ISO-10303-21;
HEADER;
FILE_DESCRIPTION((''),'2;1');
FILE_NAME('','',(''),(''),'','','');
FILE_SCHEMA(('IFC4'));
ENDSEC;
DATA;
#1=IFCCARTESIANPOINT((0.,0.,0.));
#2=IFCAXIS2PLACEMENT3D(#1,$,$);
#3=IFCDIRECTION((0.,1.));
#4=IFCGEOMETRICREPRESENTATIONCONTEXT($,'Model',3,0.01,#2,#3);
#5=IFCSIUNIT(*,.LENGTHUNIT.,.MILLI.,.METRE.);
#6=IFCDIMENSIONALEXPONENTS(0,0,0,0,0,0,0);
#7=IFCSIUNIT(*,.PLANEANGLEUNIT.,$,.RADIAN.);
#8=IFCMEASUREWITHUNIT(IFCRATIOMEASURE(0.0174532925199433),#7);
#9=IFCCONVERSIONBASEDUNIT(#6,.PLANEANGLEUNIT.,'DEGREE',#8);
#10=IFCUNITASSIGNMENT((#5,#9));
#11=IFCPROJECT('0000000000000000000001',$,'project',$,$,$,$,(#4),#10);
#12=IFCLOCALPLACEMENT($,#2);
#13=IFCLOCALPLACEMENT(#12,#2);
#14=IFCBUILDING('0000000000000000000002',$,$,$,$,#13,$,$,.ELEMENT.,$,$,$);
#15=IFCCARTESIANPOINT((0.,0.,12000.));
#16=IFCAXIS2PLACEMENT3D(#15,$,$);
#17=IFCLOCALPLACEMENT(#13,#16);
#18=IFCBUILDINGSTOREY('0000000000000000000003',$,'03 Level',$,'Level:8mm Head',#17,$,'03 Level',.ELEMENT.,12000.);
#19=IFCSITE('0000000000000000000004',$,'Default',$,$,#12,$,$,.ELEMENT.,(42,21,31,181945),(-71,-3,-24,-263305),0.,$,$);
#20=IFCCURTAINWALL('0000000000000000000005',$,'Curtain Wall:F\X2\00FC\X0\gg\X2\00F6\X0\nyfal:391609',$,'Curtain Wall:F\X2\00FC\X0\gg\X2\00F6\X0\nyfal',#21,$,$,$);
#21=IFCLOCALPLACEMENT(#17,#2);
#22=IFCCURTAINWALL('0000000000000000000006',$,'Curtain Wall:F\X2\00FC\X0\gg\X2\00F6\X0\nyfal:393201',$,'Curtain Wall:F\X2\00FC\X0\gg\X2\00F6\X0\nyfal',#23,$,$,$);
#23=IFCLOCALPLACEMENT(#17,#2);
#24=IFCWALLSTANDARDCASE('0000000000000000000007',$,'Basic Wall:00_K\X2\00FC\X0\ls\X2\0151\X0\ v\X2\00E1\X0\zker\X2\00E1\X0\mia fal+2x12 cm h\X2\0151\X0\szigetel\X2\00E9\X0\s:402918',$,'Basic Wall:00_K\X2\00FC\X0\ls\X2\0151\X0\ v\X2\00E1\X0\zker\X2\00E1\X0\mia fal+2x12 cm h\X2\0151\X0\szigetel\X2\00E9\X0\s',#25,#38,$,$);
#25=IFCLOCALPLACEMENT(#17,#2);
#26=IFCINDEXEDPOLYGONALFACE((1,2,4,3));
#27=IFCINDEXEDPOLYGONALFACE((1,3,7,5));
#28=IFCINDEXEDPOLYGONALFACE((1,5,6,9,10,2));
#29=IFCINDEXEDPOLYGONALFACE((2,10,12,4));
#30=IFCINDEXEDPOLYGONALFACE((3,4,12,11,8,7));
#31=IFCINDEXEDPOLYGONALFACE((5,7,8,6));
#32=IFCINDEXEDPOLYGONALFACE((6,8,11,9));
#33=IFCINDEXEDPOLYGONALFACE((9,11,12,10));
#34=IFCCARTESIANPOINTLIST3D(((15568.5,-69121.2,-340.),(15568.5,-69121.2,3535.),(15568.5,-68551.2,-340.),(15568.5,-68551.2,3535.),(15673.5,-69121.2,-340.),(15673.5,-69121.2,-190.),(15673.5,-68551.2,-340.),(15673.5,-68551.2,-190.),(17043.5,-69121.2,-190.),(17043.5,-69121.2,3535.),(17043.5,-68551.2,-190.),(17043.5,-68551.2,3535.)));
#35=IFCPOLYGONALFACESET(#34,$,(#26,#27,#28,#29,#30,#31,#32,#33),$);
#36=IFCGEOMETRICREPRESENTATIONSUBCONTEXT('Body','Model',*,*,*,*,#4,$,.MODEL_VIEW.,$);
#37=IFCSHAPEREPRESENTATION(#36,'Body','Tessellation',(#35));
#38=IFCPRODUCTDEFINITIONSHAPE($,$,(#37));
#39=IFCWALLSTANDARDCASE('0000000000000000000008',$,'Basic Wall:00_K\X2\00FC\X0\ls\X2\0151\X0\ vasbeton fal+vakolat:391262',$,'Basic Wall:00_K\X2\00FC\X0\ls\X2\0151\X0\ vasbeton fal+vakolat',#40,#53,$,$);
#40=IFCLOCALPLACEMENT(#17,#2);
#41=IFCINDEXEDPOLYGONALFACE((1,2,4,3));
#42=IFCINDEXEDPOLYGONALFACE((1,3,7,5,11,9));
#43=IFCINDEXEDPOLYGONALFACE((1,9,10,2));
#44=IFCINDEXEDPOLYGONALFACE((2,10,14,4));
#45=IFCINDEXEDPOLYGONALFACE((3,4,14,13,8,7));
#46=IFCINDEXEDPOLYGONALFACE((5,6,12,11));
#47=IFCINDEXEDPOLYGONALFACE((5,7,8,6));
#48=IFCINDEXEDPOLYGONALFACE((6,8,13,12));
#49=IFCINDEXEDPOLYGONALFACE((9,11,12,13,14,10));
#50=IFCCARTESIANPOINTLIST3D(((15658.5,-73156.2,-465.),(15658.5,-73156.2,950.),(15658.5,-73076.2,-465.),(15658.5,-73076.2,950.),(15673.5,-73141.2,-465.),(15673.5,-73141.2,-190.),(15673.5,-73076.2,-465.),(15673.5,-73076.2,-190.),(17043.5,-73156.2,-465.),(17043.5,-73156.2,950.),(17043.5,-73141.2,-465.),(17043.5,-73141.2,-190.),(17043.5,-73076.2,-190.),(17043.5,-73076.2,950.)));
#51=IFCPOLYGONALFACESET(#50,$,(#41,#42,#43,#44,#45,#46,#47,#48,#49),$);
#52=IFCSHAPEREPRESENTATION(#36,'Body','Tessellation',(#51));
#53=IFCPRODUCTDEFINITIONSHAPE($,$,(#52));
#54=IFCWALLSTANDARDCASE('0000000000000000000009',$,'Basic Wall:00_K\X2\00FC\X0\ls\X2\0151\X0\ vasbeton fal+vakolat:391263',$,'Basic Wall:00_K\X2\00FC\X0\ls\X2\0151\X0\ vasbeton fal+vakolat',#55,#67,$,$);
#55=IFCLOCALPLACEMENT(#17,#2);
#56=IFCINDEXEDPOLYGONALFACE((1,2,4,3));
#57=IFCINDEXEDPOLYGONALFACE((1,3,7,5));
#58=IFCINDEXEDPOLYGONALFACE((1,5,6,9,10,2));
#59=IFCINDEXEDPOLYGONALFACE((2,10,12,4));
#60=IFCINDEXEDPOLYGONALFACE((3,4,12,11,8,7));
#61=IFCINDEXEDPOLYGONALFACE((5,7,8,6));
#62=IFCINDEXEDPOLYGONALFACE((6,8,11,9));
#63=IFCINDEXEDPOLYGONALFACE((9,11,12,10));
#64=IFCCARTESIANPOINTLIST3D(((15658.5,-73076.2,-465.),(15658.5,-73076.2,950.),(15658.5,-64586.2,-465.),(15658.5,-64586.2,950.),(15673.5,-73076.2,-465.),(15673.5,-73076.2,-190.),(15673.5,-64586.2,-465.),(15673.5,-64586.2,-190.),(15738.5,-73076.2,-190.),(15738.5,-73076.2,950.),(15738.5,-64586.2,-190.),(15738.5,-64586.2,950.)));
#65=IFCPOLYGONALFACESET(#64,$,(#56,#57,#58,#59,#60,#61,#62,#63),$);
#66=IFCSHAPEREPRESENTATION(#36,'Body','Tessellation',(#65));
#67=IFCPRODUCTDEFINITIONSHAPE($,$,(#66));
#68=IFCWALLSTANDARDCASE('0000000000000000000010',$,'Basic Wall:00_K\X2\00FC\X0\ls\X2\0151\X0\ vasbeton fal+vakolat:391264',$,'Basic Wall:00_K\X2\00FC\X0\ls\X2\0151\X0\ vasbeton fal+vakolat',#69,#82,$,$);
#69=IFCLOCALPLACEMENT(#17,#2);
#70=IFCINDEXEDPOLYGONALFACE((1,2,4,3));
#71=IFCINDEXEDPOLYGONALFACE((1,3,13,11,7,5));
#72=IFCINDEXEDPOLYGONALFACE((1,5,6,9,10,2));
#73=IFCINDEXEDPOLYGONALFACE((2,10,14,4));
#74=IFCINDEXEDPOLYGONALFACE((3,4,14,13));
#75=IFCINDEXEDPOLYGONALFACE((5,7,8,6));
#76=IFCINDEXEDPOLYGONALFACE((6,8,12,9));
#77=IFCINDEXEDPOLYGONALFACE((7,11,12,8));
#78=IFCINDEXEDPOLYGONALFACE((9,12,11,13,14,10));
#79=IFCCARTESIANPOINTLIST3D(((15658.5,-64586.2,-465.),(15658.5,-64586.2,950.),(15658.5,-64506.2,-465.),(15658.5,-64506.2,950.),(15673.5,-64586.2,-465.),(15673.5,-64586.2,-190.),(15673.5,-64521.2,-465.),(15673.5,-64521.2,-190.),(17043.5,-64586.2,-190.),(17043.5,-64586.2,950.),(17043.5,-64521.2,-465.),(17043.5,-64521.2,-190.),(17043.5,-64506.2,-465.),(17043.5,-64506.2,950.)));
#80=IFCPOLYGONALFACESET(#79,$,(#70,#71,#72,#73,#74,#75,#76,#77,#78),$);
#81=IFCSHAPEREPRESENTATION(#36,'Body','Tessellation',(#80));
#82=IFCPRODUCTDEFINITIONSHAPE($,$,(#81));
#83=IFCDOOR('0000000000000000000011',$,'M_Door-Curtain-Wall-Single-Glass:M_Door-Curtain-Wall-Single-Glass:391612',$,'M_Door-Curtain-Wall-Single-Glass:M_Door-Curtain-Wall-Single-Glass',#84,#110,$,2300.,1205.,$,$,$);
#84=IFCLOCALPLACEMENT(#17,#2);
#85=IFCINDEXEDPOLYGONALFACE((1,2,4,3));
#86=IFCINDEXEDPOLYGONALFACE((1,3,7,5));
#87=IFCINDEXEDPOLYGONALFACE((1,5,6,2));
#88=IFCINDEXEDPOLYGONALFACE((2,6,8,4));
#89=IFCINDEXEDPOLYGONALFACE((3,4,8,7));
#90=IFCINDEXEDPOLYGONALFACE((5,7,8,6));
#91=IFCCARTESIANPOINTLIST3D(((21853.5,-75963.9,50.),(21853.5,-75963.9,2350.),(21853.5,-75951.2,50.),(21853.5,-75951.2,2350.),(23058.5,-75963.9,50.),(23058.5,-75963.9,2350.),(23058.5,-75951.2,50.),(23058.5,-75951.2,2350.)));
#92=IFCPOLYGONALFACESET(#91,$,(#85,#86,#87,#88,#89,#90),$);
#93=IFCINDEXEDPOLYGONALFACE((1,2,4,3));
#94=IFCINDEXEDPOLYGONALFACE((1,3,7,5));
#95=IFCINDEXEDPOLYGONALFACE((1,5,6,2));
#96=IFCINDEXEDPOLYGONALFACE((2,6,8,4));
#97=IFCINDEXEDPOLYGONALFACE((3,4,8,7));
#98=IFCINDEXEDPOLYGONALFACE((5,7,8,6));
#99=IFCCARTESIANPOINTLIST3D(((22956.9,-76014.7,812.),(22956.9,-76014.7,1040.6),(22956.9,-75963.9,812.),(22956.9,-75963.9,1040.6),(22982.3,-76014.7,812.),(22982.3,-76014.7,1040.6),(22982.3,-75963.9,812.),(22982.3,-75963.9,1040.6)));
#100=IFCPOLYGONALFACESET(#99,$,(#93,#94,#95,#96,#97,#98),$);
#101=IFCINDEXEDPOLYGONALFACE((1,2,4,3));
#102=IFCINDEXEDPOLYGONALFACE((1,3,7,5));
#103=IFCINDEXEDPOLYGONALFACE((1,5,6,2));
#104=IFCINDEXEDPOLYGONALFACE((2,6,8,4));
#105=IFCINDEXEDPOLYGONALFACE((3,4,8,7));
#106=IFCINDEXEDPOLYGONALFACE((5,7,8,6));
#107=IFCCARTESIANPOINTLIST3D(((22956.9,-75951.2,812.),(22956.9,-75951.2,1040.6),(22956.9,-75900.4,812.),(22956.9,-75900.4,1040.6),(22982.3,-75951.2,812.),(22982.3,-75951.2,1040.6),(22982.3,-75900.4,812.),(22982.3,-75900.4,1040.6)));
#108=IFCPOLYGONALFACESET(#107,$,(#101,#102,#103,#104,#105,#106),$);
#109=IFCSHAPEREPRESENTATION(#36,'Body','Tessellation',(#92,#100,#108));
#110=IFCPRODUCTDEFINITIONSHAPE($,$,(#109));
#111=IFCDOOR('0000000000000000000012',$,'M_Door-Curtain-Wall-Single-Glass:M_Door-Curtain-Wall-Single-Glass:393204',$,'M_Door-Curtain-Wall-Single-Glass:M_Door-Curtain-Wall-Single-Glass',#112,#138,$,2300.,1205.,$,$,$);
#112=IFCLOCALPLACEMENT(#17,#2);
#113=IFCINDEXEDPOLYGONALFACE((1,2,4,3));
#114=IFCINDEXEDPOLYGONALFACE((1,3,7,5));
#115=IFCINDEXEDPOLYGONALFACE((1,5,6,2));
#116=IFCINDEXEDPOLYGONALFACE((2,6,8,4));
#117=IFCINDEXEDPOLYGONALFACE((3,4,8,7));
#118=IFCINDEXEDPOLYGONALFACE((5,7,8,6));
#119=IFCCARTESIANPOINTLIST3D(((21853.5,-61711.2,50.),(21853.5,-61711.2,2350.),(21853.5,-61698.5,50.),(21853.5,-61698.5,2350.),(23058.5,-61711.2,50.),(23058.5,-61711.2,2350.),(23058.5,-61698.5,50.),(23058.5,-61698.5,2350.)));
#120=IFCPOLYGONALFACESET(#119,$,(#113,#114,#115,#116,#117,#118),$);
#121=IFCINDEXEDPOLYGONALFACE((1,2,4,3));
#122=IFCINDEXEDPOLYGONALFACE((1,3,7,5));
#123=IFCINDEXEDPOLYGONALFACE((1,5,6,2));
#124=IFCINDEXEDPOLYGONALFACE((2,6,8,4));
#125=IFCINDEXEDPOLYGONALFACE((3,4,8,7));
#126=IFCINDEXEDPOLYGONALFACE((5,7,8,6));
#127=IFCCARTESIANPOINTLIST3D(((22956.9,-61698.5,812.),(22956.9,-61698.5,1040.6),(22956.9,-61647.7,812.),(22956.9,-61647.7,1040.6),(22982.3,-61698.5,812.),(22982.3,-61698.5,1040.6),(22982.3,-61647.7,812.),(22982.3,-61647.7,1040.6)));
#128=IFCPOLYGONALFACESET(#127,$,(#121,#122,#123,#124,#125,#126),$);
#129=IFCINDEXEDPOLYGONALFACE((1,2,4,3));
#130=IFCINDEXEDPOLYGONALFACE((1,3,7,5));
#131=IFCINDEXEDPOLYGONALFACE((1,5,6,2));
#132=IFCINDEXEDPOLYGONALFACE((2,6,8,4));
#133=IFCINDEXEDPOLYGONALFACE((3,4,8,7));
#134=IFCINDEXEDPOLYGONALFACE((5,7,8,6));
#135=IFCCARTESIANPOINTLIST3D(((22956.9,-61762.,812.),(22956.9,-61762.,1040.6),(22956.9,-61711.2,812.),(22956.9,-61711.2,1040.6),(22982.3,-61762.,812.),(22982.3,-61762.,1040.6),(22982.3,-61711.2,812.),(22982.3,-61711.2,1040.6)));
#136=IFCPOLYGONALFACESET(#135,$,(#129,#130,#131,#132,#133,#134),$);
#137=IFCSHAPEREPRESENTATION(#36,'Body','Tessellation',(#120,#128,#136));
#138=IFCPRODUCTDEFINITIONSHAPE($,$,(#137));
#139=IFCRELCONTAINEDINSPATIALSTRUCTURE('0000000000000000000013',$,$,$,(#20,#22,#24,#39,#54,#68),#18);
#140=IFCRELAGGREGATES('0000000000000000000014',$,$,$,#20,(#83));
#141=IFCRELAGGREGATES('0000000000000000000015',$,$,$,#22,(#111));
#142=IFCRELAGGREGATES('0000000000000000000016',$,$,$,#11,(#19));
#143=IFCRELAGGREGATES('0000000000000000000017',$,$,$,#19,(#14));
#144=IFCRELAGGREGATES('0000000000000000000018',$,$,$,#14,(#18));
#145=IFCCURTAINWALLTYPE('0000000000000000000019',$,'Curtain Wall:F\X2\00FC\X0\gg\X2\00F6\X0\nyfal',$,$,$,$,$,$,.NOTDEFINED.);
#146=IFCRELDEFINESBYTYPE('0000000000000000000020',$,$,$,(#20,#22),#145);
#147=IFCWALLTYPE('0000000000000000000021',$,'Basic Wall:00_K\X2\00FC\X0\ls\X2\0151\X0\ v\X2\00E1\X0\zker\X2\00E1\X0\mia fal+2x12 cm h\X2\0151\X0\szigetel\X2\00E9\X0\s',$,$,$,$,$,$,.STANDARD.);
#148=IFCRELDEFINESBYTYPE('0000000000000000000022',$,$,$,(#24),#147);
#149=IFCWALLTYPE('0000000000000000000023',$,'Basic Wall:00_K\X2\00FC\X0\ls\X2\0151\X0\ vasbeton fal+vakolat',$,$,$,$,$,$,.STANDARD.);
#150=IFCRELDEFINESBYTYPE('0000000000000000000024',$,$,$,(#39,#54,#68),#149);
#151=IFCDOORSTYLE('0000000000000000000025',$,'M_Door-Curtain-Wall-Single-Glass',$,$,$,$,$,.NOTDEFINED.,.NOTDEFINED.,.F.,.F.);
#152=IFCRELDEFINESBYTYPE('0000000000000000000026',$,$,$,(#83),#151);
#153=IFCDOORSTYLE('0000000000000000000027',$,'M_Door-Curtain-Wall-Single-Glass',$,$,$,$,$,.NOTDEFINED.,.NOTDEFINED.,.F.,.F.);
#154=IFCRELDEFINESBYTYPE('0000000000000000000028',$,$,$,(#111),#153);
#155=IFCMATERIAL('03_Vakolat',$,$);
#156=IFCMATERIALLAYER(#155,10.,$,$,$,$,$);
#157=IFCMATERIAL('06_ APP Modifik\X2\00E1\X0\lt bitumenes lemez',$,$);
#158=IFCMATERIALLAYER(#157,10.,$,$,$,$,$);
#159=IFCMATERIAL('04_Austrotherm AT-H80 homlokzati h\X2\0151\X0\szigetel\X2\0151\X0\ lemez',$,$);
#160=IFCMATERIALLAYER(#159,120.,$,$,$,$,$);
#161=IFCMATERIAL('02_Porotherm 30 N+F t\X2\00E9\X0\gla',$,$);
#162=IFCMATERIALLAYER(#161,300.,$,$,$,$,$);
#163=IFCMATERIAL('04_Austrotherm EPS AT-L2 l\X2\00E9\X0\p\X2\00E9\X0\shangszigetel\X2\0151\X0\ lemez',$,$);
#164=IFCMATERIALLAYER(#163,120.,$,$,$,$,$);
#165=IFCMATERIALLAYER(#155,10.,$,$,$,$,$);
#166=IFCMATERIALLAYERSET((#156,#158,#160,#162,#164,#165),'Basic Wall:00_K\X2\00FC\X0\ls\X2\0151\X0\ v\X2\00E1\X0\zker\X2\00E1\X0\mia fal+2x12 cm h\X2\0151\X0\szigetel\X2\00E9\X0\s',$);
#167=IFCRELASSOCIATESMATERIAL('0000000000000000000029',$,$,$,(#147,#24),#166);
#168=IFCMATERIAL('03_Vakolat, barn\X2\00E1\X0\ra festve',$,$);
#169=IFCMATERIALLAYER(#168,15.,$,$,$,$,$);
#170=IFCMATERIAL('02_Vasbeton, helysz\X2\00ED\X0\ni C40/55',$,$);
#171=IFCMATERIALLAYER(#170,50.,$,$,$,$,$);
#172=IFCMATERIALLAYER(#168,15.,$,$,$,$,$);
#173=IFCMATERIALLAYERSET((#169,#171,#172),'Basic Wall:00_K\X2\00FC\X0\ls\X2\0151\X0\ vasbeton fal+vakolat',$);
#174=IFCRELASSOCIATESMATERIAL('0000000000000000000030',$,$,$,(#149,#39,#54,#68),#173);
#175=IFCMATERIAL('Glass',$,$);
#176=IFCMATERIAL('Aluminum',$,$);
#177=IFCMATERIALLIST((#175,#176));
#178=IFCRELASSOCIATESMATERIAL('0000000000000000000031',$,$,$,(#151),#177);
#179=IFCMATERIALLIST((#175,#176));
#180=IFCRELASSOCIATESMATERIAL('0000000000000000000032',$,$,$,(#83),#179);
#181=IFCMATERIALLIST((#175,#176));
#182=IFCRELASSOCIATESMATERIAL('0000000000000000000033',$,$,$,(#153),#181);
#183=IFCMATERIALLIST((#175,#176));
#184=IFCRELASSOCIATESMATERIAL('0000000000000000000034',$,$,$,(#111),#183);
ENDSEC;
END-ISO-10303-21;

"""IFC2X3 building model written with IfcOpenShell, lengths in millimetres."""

from ifc_helpers import new_model, entity, si_unit, converted_unit, direction, frame, frame_2d, origin, origin_2d_with_axis, place, context, subcontext, project, spatial, polyline, rectangle, extrude, clip, bounded_halfspace, source, transform, mapped, material, material_list, layer, layer_set, layer_usage, type_object, type_shapes, element, aggregate, save


model = new_model("IFC2X3")

# Units and contexts
model_context = context("Model", 3, precision=0.01, world=origin(), true_north=direction((0.0, 1.0)))
body_context = subcontext(model_context, "Body", "Model", "MODEL_VIEW")
ifc_project = project(units=[si_unit("LENGTHUNIT", "METRE", prefix="MILLI"), converted_unit("PLANEANGLEUNIT", "DEGREE", entity("IfcRatioMeasure", 0.0174532925199433), si_unit("PLANEANGLEUNIT", "RADIAN"), dimensions=[0, 0, 0, 0, 0, 0, 0])], contexts=[model_context])

# Site, building, storey
site_placement = place(None, origin())
site = spatial("IfcSite", under=ifc_project, at=site_placement, Name="Default", CompositionType="ELEMENT", RefLatitude=(42, 21, 31, 181945), RefLongitude=(-71, -3, -24, -263305), RefElevation=0.0)
building_placement = place(site_placement, origin())
building = spatial("IfcBuilding", under=site, at=building_placement, CompositionType="ELEMENT")
storey_placement = place(building_placement, frame((0.0, 0.0, 12000.0)))
storey = spatial("IfcBuildingStorey", under=building, at=storey_placement, Name="03 Level", ObjectType="Level:8mm Head", LongName="03 Level", CompositionType="ELEMENT", Elevation=12000.0)

# Curtain walls
curtain_wall_type = type_object("IfcCurtainWallType", Name="Curtain Wall:Függönyfal", PredefinedType="NOTDEFINED")
curtain_wall_1_placement = place(storey_placement, frame((0.0, 0.0, -12000.0)))
curtain_wall_1 = element("IfcCurtainWall", 1, at=curtain_wall_1_placement, inside=storey, type_object=curtain_wall_type, Name="Curtain Wall:Függönyfal:391609", ObjectType="Curtain Wall:Függönyfal")
curtain_wall_2_placement = place(storey_placement, frame((0.0, 0.0, -12000.0)))
curtain_wall_2 = element("IfcCurtainWall", 2, at=curtain_wall_2_placement, inside=storey, type_object=curtain_wall_type, Name="Curtain Wall:Függönyfal:393201", ObjectType="Curtain Wall:Függönyfal")

# Shared definitions
ifc_material_1 = material(Name="03_Vakolat")
ifc_material_2 = material(Name="04_Austrotherm AT-H80 homlokzati hőszigetelő lemez")
ifc_material_3 = material(Name="02_Porotherm 30 N+F tégla")

# Walls
ifc_layer_1 = layer(ifc_material_1, 10.0)
ifc_material_4 = material(Name="06_ APP Modifikált bitumenes lemez")
ifc_layer_2 = layer(ifc_material_4, 10.0)
ifc_layer_3 = layer(ifc_material_2, 120.0)
ifc_layer_4 = layer(ifc_material_3, 300.0)
ifc_material_5 = material(Name="04_Austrotherm EPS AT-L2 lépéshangszigetelő lemez")
ifc_layer_5 = layer(ifc_material_5, 120.0)
ifc_layer_6 = layer(ifc_material_1, 10.0)
ifc_layer_set_1 = layer_set([ifc_layer_1, ifc_layer_2, ifc_layer_3, ifc_layer_4, ifc_layer_5, ifc_layer_6], Name="Basic Wall:00_Külső vázkerámia fal+2x12 cm hőszigetelés")
ifc_layer_usage_1 = layer_usage(ifc_layer_set_1, "AXIS2", "NEGATIVE", 285.0)
wall_type_1 = type_object("IfcWallType", Name="Basic Wall:00_Külső vázkerámia fal+2x12 cm hőszigetelés", PredefinedType="STANDARD", material=ifc_layer_set_1)
wall_1_placement = place(storey_placement, frame((17043.5, -68836.2, -340.0), z_axis=(0.0, 0.0, 1.0), x_axis=(-1.0, 0.0, 0.0)))
element("IfcWallStandardCase", 3, at=wall_1_placement, inside=storey, type_object=wall_type_1, material=ifc_layer_usage_1, Name="Basic Wall:00_Külső vázkerámia fal+2x12 cm hőszigetelés:402918", ObjectType="Basic Wall:00_Külső vázkerámia fal+2x12 cm hőszigetelés", context=body_context, shape_type="Clipping", body=[
    clip(clip(clip(extrude(rectangle(XDim=1475.0, YDim=570.0, at=frame_2d((737.5, 0.0), x_axis=(-1.0, 0.0))), origin(), (0.0, 0.0, 1.0), 3875.0), bounded_halfspace(frame((0.0, -285.0, 3875.0), z_axis=(0.0, 0.0, -1.0), x_axis=(-1.0, 0.0, 0.0)), True, frame((0.0, -285.0, 3875.0), z_axis=(0.0, 0.0, -1.0), x_axis=(-1.0, 0.0, 0.0)), polyline([(0.0, 0.0), (0.0, 570.0), (-1475.0, 570.0), (-1475.0, 0.0), (0.0, 0.0)]))), bounded_halfspace(frame((1370.0, 285.0, 150.0)), True, frame((1370.0, 285.0, 150.0)), polyline([(0.0, 0.0), (-1370.0, 0.0), (-1370.0, -570.0), (0.0, -570.0), (0.0, 0.0)]))), bounded_halfspace(frame((1370.0, -285.0, 150.0), z_axis=(1.0, 0.0, 0.0), x_axis=(0.0, 0.0, 1.0)), True, frame((1370.0, -285.0, 150.0), z_axis=(1.0, 0.0, 0.0), x_axis=(0.0, 0.0, 1.0)), polyline([(0.0, 0.0), (-150.0, 0.0), (-150.0, -570.0), (0.0, -570.0), (0.0, 0.0)]))),
])
ifc_material_6 = material(Name="03_Vakolat, barnára festve")
ifc_layer_7 = layer(ifc_material_6, 15.0)
ifc_material_7 = material(Name="02_Vasbeton, helyszíni C40/55")
ifc_layer_8 = layer(ifc_material_7, 50.0)
ifc_layer_9 = layer(ifc_material_6, 15.0)
ifc_layer_set_2 = layer_set([ifc_layer_7, ifc_layer_8, ifc_layer_9], Name="Basic Wall:00_Külső vasbeton fal+vakolat")
ifc_layer_usage_2 = layer_usage(ifc_layer_set_2, "AXIS2", "NEGATIVE", 40.0)
wall_type_2 = type_object("IfcWallType", Name="Basic Wall:00_Külső vasbeton fal+vakolat", PredefinedType="STANDARD", material=ifc_layer_set_2)
wall_2_placement = place(storey_placement, frame((17043.5, -73116.2, -465.0), z_axis=(0.0, 0.0, 1.0), x_axis=(-1.0, 0.0, 0.0)))
element("IfcWallStandardCase", 4, at=wall_2_placement, inside=storey, type_object=wall_type_2, material=ifc_layer_usage_2, Name="Basic Wall:00_Külső vasbeton fal+vakolat:391262", ObjectType="Basic Wall:00_Külső vasbeton fal+vakolat", context=body_context, shape_type="Clipping", body=[
    clip(clip(clip(extrude(rectangle(XDim=1385.0, YDim=80.0, at=frame_2d((692.5, 0.0), x_axis=(-1.0, 0.0))), origin(), (0.0, 0.0, 1.0), 1415.0), bounded_halfspace(frame((1370.0, 25.0, 0.0), z_axis=(1.0, 0.0, 0.0), x_axis=(0.0, 0.0, 1.0)), True, frame((1370.0, 25.0, 0.0), z_axis=(1.0, 0.0, 0.0), x_axis=(0.0, 0.0, 1.0)), polyline([(0.0, 0.0), (125.0, 0.0), (275.0, 0.0), (275.0, 65.0), (0.0, 65.0), (0.0, 0.0)]))), bounded_halfspace(frame((1370.0, 25.0, 0.0), z_axis=(0.0, 1.0, 0.0), x_axis=(0.0, 0.0, 1.0)), True, frame((1370.0, 25.0, 0.0), z_axis=(0.0, 1.0, 0.0), x_axis=(0.0, 0.0, 1.0)), polyline([(0.0, 0.0), (0.0, -1370.0), (125.0, -1370.0), (275.0, -1370.0), (275.0, 0.0), (125.0, 0.0), (0.0, 0.0)]))), bounded_halfspace(frame((1370.0, 25.0, 275.0)), True, frame((1370.0, 25.0, 275.0)), polyline([(0.0, 0.0), (-1370.0, 0.0), (-1370.0, -65.0), (-65.0, -65.0), (0.0, -65.0), (0.0, 0.0)]))),
])
ifc_layer_usage_3 = layer_usage(ifc_layer_set_2, "AXIS2", "NEGATIVE", 40.0)
wall_3_placement = place(storey_placement, frame((15698.5, -73076.2, -465.0), z_axis=(0.0, 0.0, 1.0), x_axis=(0.0, 1.0, 0.0)))
element("IfcWallStandardCase", 5, at=wall_3_placement, inside=storey, type_object=wall_type_2, material=ifc_layer_usage_3, Name="Basic Wall:00_Külső vasbeton fal+vakolat:391263", ObjectType="Basic Wall:00_Külső vasbeton fal+vakolat", context=body_context, shape_type="Clipping", body=[
    clip(clip(extrude(rectangle(XDim=8490.0, YDim=80.0, at=frame_2d((4245.0, 0.0), x_axis=(-1.0, 0.0))), origin(), (0.0, 0.0, 1.0), 1415.0), bounded_halfspace(frame((0.0, 25.0, 0.0), z_axis=(0.0, 1.0, 0.0), x_axis=(0.0, 0.0, 1.0)), True, frame((0.0, 25.0, 0.0), z_axis=(0.0, 1.0, 0.0), x_axis=(0.0, 0.0, 1.0)), polyline([(0.0, 0.0), (125.0, 0.0), (275.0, 0.0), (275.0, 8490.0), (125.0, 8490.0), (0.0, 8490.0), (0.0, 0.0)]))), bounded_halfspace(frame((0.0, 25.0, 275.0), z_axis=(0.0, 0.0, 1.0), x_axis=(0.0, 1.0, 0.0)), True, frame((0.0, 25.0, 275.0), z_axis=(0.0, 0.0, 1.0), x_axis=(0.0, 1.0, 0.0)), polyline([(0.0, 0.0), (-65.0, 0.0), (-65.0, -8490.0), (0.0, -8490.0), (0.0, 0.0)]))),
])
ifc_layer_usage_4 = layer_usage(ifc_layer_set_2, "AXIS2", "POSITIVE", -40.0)
wall_4_placement = place(storey_placement, frame((17043.5, -64546.2, -465.0), z_axis=(0.0, 0.0, 1.0), x_axis=(-1.0, 0.0, 0.0)))
element("IfcWallStandardCase", 6, at=wall_4_placement, inside=storey, type_object=wall_type_2, material=ifc_layer_usage_4, Name="Basic Wall:00_Külső vasbeton fal+vakolat:391264", ObjectType="Basic Wall:00_Külső vasbeton fal+vakolat", context=body_context, shape_type="Clipping", body=[
    clip(clip(clip(extrude(rectangle(XDim=1385.0, YDim=80.0, at=frame_2d((692.5, 0.0), x_axis=(-1.0, 0.0))), origin(), (0.0, 0.0, 1.0), 1415.0), bounded_halfspace(frame((1370.0, -25.0, 275.0), z_axis=(1.0, 0.0, 0.0), x_axis=(0.0, 0.0, 1.0)), True, frame((1370.0, -25.0, 275.0), z_axis=(1.0, 0.0, 0.0), x_axis=(0.0, 0.0, 1.0)), polyline([(0.0, 0.0), (-150.0, 0.0), (-275.0, 0.0), (-275.0, -65.0), (0.0, -65.0), (0.0, 0.0)]))), bounded_halfspace(frame((1370.0, -25.0, 275.0), z_axis=(0.0, -1.0, 0.0), x_axis=(0.0, 0.0, 1.0)), True, frame((1370.0, -25.0, 275.0), z_axis=(0.0, -1.0, 0.0), x_axis=(0.0, 0.0, 1.0)), polyline([(0.0, 0.0), (0.0, 1370.0), (-150.0, 1370.0), (-275.0, 1370.0), (-275.0, 0.0), (-150.0, 0.0), (0.0, 0.0)]))), bounded_halfspace(frame((1370.0, 40.0, 275.0)), True, frame((1370.0, 40.0, 275.0)), polyline([(0.0, 0.0), (-65.0, 0.0), (-1370.0, 0.0), (-1370.0, -65.0), (0.0, -65.0), (0.0, 0.0)]))),
])

# Doors
ifc_material_8 = material(Name="Glass")
ifc_material_9 = material(Name="Aluminum")
ifc_material_list_1 = material_list([ifc_material_8, ifc_material_9])
ifc_material_list_2 = material_list([ifc_material_8, ifc_material_9])
door_style_1 = type_object("IfcDoorStyle", Name="M_Door-Curtain-Wall-Single-Glass", ConstructionType="NOTDEFINED", OperationType="NOTDEFINED", ParameterTakesPrecedence=False, Sizeable=False, material=ifc_material_list_2)
shared_shape_1 = source(origin(), body_context, "Body", "SweptSolid", [
    extrude(rectangle(XDim=12.7, YDim=1205.0, at=origin_2d_with_axis()), frame((0.0, 6.3, 0.0), z_axis=(0.0, 0.0, 1.0), x_axis=(0.0, 1.0, 0.0)), (0.0, 0.0, 1.0), 2300.0),
    extrude(rectangle(XDim=25.4, YDim=50.8, at=frame_2d((0.0, 0.0), x_axis=(1.0, 0.0))), frame((-513.6, 38.1, 762.0), z_axis=(0.0, 0.0, 1.0), x_axis=(-1.0, 0.0, 0.0)), (0.0, 0.0, 1.0), 228.6),
    extrude(rectangle(XDim=25.4, YDim=50.8, at=frame_2d((0.0, 0.0), x_axis=(1.0, 0.0))), frame((-513.6, -25.4, 762.0)), (0.0, 0.0, 1.0), 228.6),
])
type_shapes(door_style_1, [shared_shape_1])
door_1_placement = place(curtain_wall_1_placement, frame((22456.0, -75951.2, 12050.0), z_axis=(0.0, 0.0, 1.0), x_axis=(-1.0, 0.0, 0.0)))
door_1 = element("IfcDoor", 7, at=door_1_placement, type_object=door_style_1, material=ifc_material_list_1, Name="M_Door-Curtain-Wall-Single-Glass:M_Door-Curtain-Wall-Single-Glass:391612", ObjectType="M_Door-Curtain-Wall-Single-Glass:M_Door-Curtain-Wall-Single-Glass", OverallHeight=2300.0, OverallWidth=1205.0, context=body_context, shape_type="MappedRepresentation", body=[
    mapped(shared_shape_1, transform((0.0, 0.0, 0.0), scale=1.0)),
])
aggregate(curtain_wall_1, [door_1])
ifc_material_list_3 = material_list([ifc_material_8, ifc_material_9])
ifc_material_list_4 = material_list([ifc_material_8, ifc_material_9])
door_style_2 = type_object("IfcDoorStyle", Name="M_Door-Curtain-Wall-Single-Glass", ConstructionType="NOTDEFINED", OperationType="NOTDEFINED", ParameterTakesPrecedence=False, Sizeable=False, material=ifc_material_list_4)
shared_shape_2 = source(origin(), body_context, "Body", "SweptSolid", [
    extrude(rectangle(XDim=1205.0, YDim=12.7, at=origin_2d_with_axis()), frame((0.0, -6.3, 0.0), z_axis=(0.0, 0.0, 1.0), x_axis=(-1.0, 0.0, 0.0)), (0.0, 0.0, 1.0), 2300.0),
    extrude(rectangle(XDim=50.8, YDim=25.4, at=frame_2d((0.0, 0.0), x_axis=(1.0, 0.0))), frame((-513.6, -38.1, 762.0), z_axis=(0.0, 0.0, 1.0), x_axis=(0.0, 1.0, 0.0)), (0.0, 0.0, 1.0), 228.6),
    extrude(rectangle(XDim=50.8, YDim=25.4, at=frame_2d((0.0, 0.0), x_axis=(1.0, 0.0))), frame((-513.6, 25.4, 762.0), z_axis=(0.0, 0.0, 1.0), x_axis=(0.0, -1.0, 0.0)), (0.0, 0.0, 1.0), 228.6),
])
type_shapes(door_style_2, [shared_shape_2])
door_2_placement = place(curtain_wall_2_placement, frame((22456.0, -61711.2, 12050.0), z_axis=(0.0, 0.0, 1.0), x_axis=(-1.0, 0.0, 0.0)))
door_2 = element("IfcDoor", 8, at=door_2_placement, type_object=door_style_2, material=ifc_material_list_3, Name="M_Door-Curtain-Wall-Single-Glass:M_Door-Curtain-Wall-Single-Glass:393204", ObjectType="M_Door-Curtain-Wall-Single-Glass:M_Door-Curtain-Wall-Single-Glass", OverallHeight=2300.0, OverallWidth=1205.0, context=body_context, shape_type="MappedRepresentation", body=[
    mapped(shared_shape_2, transform((0.0, 0.0, 0.0), scale=1.0)),
])
aggregate(curtain_wall_2, [door_2])

save(model, "model.ifc")
